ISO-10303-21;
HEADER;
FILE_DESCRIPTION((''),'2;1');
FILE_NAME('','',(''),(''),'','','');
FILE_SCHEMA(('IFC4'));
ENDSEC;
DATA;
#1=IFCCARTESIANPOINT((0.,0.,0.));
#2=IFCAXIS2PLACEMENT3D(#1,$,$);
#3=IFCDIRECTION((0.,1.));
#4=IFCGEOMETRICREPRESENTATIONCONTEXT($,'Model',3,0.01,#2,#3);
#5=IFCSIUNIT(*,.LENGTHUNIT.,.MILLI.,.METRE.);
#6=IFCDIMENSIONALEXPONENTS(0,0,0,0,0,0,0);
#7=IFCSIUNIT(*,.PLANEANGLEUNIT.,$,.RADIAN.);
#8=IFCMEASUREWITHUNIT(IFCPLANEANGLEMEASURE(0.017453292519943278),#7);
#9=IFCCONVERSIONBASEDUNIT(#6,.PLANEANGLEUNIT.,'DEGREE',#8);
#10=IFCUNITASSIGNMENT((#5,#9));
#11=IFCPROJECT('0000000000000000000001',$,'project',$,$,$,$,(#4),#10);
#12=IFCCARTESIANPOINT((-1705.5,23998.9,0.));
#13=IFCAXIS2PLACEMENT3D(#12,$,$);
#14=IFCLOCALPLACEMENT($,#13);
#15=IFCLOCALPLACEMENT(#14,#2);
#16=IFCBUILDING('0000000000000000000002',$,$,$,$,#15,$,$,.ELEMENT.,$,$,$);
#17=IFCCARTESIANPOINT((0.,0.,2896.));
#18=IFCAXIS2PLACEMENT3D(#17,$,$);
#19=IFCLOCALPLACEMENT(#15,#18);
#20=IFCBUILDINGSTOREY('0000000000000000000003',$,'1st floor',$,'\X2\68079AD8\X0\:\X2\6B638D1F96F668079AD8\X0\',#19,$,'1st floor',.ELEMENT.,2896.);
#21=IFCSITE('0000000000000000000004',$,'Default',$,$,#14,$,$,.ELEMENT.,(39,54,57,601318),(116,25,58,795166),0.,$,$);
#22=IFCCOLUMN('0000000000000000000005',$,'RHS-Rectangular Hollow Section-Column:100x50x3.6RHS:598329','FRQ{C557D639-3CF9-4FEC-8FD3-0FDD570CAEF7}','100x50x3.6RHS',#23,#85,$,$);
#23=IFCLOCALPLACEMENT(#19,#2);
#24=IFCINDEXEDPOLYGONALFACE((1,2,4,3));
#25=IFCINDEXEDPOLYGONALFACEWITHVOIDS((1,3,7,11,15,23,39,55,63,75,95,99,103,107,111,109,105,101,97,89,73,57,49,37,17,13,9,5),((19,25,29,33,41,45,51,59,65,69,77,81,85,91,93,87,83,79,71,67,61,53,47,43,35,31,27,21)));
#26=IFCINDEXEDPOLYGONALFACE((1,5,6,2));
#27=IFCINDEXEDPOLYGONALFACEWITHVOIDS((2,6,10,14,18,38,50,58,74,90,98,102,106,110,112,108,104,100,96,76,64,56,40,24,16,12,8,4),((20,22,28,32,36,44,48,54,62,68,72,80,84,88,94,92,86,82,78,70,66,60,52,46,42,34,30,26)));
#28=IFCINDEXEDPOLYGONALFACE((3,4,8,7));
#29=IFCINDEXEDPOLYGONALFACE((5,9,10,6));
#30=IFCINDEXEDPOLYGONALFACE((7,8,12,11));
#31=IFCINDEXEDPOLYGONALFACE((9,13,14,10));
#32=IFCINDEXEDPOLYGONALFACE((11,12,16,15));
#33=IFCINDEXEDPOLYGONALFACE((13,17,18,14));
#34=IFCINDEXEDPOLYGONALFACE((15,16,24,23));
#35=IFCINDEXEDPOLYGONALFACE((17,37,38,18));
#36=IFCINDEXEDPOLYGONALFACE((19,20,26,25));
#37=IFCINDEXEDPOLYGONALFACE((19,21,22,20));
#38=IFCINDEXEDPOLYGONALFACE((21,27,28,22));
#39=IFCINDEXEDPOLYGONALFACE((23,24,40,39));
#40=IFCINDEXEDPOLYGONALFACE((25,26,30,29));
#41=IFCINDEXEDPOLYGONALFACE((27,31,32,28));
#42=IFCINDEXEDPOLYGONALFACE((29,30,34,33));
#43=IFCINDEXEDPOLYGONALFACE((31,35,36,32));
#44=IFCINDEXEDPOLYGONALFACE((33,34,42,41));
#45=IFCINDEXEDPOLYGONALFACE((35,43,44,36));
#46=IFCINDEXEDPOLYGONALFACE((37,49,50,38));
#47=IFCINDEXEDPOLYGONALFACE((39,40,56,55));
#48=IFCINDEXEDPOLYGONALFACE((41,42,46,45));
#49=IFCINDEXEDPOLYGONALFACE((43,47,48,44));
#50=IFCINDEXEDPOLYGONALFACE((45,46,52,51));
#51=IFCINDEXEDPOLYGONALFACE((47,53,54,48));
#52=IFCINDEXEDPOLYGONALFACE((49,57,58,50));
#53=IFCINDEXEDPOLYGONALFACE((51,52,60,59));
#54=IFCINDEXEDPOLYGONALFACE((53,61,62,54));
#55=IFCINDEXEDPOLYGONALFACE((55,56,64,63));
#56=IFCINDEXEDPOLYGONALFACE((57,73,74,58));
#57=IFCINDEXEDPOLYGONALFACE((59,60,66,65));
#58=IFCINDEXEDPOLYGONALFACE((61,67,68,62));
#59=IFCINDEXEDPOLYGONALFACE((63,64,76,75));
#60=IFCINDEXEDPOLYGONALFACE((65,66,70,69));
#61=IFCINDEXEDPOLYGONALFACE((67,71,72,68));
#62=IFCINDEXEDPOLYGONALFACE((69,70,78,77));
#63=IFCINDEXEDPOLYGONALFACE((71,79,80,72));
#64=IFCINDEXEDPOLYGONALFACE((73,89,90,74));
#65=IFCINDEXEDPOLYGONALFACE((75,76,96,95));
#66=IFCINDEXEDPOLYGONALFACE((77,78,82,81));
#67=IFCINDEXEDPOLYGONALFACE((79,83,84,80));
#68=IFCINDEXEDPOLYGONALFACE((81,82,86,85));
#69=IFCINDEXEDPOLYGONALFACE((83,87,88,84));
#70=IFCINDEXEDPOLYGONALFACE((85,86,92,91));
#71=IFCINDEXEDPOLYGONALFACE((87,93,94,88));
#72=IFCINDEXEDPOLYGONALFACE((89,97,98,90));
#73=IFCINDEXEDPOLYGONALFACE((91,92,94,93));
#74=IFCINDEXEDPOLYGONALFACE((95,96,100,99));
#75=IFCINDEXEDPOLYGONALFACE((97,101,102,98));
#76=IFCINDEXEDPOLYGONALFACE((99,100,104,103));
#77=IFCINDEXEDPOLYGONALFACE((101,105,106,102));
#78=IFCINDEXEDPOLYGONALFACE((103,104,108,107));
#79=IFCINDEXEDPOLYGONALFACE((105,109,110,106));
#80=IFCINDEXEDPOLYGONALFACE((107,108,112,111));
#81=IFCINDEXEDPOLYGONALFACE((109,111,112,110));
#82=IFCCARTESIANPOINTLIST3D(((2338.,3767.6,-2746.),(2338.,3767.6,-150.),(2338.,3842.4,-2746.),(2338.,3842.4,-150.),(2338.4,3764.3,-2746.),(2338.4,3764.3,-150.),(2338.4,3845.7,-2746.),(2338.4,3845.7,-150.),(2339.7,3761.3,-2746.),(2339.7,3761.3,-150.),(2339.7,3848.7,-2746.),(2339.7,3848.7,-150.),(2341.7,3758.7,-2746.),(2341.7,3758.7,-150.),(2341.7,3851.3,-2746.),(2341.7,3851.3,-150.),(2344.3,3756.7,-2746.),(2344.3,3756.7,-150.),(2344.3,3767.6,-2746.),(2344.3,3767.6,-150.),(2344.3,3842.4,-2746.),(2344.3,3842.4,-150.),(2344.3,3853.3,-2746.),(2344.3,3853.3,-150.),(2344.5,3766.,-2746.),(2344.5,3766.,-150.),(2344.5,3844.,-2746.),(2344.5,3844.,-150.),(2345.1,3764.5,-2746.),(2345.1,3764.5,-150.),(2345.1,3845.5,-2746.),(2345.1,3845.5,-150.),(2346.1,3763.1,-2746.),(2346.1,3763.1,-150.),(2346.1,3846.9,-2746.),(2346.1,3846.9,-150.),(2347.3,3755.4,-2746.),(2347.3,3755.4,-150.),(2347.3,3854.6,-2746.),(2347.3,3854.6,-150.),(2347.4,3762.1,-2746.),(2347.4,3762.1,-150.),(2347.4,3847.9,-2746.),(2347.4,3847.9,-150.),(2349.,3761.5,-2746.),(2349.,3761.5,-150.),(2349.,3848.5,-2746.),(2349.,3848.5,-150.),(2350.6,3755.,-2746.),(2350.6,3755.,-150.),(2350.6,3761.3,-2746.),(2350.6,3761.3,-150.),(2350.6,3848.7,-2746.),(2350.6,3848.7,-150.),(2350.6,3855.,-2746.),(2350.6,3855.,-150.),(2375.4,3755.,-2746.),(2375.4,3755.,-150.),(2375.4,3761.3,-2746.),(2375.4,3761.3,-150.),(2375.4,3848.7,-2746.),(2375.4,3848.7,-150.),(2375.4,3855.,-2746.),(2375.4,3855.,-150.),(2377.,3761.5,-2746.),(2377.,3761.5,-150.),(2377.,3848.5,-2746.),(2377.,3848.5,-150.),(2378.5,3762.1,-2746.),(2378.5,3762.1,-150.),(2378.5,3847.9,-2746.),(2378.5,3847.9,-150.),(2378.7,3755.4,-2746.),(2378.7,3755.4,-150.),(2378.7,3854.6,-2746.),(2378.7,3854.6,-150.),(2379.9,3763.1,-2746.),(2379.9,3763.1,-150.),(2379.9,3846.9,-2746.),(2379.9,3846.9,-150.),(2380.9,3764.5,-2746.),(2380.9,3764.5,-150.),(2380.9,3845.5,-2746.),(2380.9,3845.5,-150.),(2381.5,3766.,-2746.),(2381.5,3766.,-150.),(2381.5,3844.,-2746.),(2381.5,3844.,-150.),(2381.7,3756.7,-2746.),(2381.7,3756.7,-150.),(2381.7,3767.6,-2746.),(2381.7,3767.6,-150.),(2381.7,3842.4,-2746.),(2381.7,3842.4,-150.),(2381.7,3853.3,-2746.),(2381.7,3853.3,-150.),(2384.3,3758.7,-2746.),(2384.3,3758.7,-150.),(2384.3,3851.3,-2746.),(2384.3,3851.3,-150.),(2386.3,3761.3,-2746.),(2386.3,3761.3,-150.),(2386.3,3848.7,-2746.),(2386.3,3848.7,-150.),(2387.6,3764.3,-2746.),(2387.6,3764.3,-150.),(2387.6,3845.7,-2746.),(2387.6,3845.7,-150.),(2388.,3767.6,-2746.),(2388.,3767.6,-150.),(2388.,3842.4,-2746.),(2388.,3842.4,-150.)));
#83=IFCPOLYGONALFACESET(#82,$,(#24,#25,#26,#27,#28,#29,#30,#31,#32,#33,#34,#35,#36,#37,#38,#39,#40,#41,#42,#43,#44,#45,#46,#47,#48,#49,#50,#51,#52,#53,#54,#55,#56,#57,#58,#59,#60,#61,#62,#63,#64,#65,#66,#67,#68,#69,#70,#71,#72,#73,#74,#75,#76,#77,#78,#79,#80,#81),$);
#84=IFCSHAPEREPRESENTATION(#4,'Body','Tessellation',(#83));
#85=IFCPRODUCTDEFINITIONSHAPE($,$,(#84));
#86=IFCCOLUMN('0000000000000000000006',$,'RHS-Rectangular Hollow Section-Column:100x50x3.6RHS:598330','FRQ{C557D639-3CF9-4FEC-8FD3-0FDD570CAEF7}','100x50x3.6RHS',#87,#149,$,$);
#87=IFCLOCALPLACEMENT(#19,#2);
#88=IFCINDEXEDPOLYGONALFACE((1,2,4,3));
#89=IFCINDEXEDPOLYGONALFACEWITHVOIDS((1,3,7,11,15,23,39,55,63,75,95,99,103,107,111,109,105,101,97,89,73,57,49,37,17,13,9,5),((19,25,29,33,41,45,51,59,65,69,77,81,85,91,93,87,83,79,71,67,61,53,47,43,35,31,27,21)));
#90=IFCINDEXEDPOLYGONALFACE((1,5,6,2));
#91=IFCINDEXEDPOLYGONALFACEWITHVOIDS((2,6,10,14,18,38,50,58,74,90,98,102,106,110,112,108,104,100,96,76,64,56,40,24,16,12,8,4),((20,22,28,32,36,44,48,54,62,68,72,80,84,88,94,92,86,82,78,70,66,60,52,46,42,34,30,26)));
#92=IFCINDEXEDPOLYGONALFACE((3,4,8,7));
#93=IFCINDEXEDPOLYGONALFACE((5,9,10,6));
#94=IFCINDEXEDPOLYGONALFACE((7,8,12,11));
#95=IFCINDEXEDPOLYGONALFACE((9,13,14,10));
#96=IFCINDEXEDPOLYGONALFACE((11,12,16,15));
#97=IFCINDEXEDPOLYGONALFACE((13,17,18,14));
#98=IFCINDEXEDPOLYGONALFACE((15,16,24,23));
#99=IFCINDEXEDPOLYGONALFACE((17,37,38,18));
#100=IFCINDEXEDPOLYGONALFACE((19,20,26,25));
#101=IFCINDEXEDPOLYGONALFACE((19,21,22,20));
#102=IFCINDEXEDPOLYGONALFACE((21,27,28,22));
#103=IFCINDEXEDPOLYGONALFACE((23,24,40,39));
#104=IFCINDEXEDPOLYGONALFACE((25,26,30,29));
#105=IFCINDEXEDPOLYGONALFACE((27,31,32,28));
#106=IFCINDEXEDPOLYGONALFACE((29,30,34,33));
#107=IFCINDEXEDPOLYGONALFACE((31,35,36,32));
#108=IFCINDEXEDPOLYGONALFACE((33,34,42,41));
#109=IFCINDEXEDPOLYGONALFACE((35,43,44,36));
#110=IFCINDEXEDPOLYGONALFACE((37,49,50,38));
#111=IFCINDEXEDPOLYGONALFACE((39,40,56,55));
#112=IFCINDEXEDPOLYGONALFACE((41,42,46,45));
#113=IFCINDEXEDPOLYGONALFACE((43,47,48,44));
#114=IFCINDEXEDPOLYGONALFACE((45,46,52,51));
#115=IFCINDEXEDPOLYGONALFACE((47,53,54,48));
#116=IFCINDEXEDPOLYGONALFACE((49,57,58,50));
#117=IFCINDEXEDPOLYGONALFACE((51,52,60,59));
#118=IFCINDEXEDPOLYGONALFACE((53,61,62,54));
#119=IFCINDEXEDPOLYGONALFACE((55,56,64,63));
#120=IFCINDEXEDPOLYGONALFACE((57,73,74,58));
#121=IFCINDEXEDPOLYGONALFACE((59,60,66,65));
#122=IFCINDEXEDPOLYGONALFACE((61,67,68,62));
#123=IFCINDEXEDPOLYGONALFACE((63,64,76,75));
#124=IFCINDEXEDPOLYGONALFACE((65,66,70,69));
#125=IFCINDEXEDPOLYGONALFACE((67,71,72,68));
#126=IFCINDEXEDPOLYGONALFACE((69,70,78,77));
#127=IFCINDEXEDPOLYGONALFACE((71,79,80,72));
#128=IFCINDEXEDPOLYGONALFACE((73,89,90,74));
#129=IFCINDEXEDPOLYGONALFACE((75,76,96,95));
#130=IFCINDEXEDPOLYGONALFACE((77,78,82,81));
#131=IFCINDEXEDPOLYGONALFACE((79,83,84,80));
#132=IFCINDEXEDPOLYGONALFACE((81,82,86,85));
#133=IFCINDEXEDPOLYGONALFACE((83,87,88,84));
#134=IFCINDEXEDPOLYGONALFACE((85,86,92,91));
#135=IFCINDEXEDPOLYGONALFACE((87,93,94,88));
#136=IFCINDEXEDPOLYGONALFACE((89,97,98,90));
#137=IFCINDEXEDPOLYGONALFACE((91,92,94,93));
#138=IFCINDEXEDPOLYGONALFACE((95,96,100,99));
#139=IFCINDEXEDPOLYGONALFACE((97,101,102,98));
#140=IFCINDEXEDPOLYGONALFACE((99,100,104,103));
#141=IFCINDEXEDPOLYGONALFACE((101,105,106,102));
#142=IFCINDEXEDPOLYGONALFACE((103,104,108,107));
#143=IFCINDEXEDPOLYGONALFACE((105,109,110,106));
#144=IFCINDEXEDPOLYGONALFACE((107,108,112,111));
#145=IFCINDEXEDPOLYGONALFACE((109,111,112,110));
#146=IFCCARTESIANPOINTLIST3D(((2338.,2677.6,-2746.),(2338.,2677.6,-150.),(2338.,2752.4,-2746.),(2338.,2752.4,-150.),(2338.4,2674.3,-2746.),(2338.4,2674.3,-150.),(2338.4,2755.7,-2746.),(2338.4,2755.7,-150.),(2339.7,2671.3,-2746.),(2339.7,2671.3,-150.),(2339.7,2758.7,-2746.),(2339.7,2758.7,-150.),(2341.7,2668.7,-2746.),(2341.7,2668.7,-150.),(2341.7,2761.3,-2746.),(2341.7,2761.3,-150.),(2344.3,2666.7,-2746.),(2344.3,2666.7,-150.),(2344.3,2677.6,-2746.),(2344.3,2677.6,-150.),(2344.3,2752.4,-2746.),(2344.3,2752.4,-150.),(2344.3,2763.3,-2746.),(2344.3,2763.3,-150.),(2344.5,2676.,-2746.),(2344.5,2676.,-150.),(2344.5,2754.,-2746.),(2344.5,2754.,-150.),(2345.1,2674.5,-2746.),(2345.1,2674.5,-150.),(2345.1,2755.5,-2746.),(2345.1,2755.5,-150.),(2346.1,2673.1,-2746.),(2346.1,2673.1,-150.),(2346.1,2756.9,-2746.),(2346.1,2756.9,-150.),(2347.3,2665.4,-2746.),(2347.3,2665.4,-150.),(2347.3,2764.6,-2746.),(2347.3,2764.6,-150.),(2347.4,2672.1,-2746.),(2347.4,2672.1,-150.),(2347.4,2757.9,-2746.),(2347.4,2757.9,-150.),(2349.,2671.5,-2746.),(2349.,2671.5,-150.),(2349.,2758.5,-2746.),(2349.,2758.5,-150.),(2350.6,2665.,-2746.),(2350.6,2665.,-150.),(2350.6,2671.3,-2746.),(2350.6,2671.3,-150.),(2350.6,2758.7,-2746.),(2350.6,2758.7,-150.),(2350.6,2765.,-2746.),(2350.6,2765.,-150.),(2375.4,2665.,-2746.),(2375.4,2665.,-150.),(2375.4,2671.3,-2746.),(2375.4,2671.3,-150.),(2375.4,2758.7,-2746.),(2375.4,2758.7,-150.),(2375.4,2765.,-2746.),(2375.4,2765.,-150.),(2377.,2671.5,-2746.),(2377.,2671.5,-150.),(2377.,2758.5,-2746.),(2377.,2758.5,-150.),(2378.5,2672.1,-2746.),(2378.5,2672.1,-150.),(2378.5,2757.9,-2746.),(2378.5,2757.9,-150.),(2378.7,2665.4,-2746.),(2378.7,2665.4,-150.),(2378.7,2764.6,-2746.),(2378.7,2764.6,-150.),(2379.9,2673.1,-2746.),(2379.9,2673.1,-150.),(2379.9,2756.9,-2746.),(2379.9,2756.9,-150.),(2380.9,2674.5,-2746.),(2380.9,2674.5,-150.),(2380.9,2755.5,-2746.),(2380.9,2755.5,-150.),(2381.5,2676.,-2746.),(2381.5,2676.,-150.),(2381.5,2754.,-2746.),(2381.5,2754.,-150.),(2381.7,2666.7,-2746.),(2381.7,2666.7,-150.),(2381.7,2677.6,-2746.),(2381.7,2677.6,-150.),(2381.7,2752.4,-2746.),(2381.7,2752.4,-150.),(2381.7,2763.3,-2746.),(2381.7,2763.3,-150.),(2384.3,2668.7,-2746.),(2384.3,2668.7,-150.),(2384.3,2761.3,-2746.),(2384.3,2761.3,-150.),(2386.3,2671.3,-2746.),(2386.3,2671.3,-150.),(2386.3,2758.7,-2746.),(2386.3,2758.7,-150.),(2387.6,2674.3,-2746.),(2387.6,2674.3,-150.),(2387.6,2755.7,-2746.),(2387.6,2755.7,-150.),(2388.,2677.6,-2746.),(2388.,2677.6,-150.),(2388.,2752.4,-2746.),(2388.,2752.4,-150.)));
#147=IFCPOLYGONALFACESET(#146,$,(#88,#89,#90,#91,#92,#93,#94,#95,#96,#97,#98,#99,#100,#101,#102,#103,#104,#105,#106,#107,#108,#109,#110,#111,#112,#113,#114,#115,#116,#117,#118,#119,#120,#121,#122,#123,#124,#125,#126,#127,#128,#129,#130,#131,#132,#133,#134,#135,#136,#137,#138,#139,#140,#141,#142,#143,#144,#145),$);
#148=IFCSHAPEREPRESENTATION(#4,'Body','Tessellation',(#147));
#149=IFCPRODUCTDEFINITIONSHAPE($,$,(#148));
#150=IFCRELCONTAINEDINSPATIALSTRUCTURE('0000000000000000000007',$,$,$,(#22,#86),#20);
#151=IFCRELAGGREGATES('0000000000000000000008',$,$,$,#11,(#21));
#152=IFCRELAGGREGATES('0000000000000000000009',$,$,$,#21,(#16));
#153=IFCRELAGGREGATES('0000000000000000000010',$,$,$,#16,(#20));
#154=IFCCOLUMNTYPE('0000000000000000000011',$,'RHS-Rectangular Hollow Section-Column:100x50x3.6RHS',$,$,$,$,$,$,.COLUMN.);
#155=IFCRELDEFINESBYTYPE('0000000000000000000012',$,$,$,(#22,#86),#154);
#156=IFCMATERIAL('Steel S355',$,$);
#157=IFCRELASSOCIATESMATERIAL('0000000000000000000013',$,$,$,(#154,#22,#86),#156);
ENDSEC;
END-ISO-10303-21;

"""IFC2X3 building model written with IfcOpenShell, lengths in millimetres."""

from ifc_helpers import new_model, entity, si_unit, converted_unit, direction, frame, origin, origin_2d, place, context, project, spatial, hollow_rectangle, extrude, clip, halfspace, material, type_object, element, save


model = new_model("IFC2X3")

# Units and contexts
model_context = context("Model", 3, precision=0.01, world=origin(), true_north=direction((0.0, 1.0)))
ifc_project = project(units=[si_unit("LENGTHUNIT", "METRE", prefix="MILLI"), converted_unit("PLANEANGLEUNIT", "DEGREE", entity("IfcPlaneAngleMeasure", 0.017453292519943278), si_unit("PLANEANGLEUNIT", "RADIAN"), dimensions=[0, 0, 0, 0, 0, 0, 0])], contexts=[model_context])

# Site, building, storey
site_placement = place(None, frame((-1705.5, 23998.9, 0.0)))
site = spatial("IfcSite", under=ifc_project, at=site_placement, Name="Default", CompositionType="ELEMENT", RefLatitude=(39, 54, 57, 601318), RefLongitude=(116, 25, 58, 795166), RefElevation=0.0)
building_placement = place(site_placement, origin())
building = spatial("IfcBuilding", under=site, at=building_placement, CompositionType="ELEMENT")
storey_placement = place(building_placement, frame((0.0, 0.0, 2896.0)))
storey = spatial("IfcBuildingStorey", under=building, at=storey_placement, Name="1st floor", ObjectType="标高:正负零标高", LongName="1st floor", CompositionType="ELEMENT", Elevation=2896.0)

# Shared definitions
ifc_material_1 = material(Name="Steel S355")

# Columns
column_type_1 = type_object("IfcColumnType", Name="RHS-Rectangular Hollow Section-Column:100x50x3.6RHS", PredefinedType="COLUMN", material=ifc_material_1)
column_1_placement = place(storey_placement, frame((2363.0, 3805.0, -150.0), z_axis=(0.0, 0.0, 1.0), x_axis=(-1.0, 0.0, 0.0)))
element("IfcColumn", 1, at=column_1_placement, inside=storey, type_object=column_type_1, material=ifc_material_1, Name="RHS-Rectangular Hollow Section-Column:100x50x3.6RHS:598329", Description="FRQ{C557D639-3CF9-4FEC-8FD3-0FDD570CAEF7}", ObjectType="100x50x3.6RHS", context=model_context, shape_type="Clipping", body=[
    clip(extrude(hollow_rectangle(XDim=50.0, YDim=100.0, WallThickness=6.3, InnerFilletRadius=6.3, OuterFilletRadius=12.6, at=origin_2d()), origin(), (0.0, 0.0, -1.0), 2651.9), halfspace(frame((2363.0, 3805.0, -2596.0), z_axis=(0.0, 0.0, 1.0), x_axis=(-1.0, 0.0, 0.0)), True)),
])
column_2_placement = place(storey_placement, frame((2363.0, 2715.0, -150.0), z_axis=(0.0, 0.0, 1.0), x_axis=(-1.0, 0.0, 0.0)))
element("IfcColumn", 2, at=column_2_placement, inside=storey, type_object=column_type_1, material=ifc_material_1, Name="RHS-Rectangular Hollow Section-Column:100x50x3.6RHS:598330", Description="FRQ{C557D639-3CF9-4FEC-8FD3-0FDD570CAEF7}", ObjectType="100x50x3.6RHS", context=model_context, shape_type="Clipping", body=[
    clip(extrude(hollow_rectangle(XDim=50.0, YDim=100.0, WallThickness=6.3, InnerFilletRadius=6.3, OuterFilletRadius=12.6, at=origin_2d()), origin(), (0.0, 0.0, -1.0), 2651.9), halfspace(frame((2363.0, 2715.0, -2596.0), z_axis=(0.0, 0.0, 1.0), x_axis=(-1.0, 0.0, 0.0)), True)),
])

save(model, "model.ifc")
